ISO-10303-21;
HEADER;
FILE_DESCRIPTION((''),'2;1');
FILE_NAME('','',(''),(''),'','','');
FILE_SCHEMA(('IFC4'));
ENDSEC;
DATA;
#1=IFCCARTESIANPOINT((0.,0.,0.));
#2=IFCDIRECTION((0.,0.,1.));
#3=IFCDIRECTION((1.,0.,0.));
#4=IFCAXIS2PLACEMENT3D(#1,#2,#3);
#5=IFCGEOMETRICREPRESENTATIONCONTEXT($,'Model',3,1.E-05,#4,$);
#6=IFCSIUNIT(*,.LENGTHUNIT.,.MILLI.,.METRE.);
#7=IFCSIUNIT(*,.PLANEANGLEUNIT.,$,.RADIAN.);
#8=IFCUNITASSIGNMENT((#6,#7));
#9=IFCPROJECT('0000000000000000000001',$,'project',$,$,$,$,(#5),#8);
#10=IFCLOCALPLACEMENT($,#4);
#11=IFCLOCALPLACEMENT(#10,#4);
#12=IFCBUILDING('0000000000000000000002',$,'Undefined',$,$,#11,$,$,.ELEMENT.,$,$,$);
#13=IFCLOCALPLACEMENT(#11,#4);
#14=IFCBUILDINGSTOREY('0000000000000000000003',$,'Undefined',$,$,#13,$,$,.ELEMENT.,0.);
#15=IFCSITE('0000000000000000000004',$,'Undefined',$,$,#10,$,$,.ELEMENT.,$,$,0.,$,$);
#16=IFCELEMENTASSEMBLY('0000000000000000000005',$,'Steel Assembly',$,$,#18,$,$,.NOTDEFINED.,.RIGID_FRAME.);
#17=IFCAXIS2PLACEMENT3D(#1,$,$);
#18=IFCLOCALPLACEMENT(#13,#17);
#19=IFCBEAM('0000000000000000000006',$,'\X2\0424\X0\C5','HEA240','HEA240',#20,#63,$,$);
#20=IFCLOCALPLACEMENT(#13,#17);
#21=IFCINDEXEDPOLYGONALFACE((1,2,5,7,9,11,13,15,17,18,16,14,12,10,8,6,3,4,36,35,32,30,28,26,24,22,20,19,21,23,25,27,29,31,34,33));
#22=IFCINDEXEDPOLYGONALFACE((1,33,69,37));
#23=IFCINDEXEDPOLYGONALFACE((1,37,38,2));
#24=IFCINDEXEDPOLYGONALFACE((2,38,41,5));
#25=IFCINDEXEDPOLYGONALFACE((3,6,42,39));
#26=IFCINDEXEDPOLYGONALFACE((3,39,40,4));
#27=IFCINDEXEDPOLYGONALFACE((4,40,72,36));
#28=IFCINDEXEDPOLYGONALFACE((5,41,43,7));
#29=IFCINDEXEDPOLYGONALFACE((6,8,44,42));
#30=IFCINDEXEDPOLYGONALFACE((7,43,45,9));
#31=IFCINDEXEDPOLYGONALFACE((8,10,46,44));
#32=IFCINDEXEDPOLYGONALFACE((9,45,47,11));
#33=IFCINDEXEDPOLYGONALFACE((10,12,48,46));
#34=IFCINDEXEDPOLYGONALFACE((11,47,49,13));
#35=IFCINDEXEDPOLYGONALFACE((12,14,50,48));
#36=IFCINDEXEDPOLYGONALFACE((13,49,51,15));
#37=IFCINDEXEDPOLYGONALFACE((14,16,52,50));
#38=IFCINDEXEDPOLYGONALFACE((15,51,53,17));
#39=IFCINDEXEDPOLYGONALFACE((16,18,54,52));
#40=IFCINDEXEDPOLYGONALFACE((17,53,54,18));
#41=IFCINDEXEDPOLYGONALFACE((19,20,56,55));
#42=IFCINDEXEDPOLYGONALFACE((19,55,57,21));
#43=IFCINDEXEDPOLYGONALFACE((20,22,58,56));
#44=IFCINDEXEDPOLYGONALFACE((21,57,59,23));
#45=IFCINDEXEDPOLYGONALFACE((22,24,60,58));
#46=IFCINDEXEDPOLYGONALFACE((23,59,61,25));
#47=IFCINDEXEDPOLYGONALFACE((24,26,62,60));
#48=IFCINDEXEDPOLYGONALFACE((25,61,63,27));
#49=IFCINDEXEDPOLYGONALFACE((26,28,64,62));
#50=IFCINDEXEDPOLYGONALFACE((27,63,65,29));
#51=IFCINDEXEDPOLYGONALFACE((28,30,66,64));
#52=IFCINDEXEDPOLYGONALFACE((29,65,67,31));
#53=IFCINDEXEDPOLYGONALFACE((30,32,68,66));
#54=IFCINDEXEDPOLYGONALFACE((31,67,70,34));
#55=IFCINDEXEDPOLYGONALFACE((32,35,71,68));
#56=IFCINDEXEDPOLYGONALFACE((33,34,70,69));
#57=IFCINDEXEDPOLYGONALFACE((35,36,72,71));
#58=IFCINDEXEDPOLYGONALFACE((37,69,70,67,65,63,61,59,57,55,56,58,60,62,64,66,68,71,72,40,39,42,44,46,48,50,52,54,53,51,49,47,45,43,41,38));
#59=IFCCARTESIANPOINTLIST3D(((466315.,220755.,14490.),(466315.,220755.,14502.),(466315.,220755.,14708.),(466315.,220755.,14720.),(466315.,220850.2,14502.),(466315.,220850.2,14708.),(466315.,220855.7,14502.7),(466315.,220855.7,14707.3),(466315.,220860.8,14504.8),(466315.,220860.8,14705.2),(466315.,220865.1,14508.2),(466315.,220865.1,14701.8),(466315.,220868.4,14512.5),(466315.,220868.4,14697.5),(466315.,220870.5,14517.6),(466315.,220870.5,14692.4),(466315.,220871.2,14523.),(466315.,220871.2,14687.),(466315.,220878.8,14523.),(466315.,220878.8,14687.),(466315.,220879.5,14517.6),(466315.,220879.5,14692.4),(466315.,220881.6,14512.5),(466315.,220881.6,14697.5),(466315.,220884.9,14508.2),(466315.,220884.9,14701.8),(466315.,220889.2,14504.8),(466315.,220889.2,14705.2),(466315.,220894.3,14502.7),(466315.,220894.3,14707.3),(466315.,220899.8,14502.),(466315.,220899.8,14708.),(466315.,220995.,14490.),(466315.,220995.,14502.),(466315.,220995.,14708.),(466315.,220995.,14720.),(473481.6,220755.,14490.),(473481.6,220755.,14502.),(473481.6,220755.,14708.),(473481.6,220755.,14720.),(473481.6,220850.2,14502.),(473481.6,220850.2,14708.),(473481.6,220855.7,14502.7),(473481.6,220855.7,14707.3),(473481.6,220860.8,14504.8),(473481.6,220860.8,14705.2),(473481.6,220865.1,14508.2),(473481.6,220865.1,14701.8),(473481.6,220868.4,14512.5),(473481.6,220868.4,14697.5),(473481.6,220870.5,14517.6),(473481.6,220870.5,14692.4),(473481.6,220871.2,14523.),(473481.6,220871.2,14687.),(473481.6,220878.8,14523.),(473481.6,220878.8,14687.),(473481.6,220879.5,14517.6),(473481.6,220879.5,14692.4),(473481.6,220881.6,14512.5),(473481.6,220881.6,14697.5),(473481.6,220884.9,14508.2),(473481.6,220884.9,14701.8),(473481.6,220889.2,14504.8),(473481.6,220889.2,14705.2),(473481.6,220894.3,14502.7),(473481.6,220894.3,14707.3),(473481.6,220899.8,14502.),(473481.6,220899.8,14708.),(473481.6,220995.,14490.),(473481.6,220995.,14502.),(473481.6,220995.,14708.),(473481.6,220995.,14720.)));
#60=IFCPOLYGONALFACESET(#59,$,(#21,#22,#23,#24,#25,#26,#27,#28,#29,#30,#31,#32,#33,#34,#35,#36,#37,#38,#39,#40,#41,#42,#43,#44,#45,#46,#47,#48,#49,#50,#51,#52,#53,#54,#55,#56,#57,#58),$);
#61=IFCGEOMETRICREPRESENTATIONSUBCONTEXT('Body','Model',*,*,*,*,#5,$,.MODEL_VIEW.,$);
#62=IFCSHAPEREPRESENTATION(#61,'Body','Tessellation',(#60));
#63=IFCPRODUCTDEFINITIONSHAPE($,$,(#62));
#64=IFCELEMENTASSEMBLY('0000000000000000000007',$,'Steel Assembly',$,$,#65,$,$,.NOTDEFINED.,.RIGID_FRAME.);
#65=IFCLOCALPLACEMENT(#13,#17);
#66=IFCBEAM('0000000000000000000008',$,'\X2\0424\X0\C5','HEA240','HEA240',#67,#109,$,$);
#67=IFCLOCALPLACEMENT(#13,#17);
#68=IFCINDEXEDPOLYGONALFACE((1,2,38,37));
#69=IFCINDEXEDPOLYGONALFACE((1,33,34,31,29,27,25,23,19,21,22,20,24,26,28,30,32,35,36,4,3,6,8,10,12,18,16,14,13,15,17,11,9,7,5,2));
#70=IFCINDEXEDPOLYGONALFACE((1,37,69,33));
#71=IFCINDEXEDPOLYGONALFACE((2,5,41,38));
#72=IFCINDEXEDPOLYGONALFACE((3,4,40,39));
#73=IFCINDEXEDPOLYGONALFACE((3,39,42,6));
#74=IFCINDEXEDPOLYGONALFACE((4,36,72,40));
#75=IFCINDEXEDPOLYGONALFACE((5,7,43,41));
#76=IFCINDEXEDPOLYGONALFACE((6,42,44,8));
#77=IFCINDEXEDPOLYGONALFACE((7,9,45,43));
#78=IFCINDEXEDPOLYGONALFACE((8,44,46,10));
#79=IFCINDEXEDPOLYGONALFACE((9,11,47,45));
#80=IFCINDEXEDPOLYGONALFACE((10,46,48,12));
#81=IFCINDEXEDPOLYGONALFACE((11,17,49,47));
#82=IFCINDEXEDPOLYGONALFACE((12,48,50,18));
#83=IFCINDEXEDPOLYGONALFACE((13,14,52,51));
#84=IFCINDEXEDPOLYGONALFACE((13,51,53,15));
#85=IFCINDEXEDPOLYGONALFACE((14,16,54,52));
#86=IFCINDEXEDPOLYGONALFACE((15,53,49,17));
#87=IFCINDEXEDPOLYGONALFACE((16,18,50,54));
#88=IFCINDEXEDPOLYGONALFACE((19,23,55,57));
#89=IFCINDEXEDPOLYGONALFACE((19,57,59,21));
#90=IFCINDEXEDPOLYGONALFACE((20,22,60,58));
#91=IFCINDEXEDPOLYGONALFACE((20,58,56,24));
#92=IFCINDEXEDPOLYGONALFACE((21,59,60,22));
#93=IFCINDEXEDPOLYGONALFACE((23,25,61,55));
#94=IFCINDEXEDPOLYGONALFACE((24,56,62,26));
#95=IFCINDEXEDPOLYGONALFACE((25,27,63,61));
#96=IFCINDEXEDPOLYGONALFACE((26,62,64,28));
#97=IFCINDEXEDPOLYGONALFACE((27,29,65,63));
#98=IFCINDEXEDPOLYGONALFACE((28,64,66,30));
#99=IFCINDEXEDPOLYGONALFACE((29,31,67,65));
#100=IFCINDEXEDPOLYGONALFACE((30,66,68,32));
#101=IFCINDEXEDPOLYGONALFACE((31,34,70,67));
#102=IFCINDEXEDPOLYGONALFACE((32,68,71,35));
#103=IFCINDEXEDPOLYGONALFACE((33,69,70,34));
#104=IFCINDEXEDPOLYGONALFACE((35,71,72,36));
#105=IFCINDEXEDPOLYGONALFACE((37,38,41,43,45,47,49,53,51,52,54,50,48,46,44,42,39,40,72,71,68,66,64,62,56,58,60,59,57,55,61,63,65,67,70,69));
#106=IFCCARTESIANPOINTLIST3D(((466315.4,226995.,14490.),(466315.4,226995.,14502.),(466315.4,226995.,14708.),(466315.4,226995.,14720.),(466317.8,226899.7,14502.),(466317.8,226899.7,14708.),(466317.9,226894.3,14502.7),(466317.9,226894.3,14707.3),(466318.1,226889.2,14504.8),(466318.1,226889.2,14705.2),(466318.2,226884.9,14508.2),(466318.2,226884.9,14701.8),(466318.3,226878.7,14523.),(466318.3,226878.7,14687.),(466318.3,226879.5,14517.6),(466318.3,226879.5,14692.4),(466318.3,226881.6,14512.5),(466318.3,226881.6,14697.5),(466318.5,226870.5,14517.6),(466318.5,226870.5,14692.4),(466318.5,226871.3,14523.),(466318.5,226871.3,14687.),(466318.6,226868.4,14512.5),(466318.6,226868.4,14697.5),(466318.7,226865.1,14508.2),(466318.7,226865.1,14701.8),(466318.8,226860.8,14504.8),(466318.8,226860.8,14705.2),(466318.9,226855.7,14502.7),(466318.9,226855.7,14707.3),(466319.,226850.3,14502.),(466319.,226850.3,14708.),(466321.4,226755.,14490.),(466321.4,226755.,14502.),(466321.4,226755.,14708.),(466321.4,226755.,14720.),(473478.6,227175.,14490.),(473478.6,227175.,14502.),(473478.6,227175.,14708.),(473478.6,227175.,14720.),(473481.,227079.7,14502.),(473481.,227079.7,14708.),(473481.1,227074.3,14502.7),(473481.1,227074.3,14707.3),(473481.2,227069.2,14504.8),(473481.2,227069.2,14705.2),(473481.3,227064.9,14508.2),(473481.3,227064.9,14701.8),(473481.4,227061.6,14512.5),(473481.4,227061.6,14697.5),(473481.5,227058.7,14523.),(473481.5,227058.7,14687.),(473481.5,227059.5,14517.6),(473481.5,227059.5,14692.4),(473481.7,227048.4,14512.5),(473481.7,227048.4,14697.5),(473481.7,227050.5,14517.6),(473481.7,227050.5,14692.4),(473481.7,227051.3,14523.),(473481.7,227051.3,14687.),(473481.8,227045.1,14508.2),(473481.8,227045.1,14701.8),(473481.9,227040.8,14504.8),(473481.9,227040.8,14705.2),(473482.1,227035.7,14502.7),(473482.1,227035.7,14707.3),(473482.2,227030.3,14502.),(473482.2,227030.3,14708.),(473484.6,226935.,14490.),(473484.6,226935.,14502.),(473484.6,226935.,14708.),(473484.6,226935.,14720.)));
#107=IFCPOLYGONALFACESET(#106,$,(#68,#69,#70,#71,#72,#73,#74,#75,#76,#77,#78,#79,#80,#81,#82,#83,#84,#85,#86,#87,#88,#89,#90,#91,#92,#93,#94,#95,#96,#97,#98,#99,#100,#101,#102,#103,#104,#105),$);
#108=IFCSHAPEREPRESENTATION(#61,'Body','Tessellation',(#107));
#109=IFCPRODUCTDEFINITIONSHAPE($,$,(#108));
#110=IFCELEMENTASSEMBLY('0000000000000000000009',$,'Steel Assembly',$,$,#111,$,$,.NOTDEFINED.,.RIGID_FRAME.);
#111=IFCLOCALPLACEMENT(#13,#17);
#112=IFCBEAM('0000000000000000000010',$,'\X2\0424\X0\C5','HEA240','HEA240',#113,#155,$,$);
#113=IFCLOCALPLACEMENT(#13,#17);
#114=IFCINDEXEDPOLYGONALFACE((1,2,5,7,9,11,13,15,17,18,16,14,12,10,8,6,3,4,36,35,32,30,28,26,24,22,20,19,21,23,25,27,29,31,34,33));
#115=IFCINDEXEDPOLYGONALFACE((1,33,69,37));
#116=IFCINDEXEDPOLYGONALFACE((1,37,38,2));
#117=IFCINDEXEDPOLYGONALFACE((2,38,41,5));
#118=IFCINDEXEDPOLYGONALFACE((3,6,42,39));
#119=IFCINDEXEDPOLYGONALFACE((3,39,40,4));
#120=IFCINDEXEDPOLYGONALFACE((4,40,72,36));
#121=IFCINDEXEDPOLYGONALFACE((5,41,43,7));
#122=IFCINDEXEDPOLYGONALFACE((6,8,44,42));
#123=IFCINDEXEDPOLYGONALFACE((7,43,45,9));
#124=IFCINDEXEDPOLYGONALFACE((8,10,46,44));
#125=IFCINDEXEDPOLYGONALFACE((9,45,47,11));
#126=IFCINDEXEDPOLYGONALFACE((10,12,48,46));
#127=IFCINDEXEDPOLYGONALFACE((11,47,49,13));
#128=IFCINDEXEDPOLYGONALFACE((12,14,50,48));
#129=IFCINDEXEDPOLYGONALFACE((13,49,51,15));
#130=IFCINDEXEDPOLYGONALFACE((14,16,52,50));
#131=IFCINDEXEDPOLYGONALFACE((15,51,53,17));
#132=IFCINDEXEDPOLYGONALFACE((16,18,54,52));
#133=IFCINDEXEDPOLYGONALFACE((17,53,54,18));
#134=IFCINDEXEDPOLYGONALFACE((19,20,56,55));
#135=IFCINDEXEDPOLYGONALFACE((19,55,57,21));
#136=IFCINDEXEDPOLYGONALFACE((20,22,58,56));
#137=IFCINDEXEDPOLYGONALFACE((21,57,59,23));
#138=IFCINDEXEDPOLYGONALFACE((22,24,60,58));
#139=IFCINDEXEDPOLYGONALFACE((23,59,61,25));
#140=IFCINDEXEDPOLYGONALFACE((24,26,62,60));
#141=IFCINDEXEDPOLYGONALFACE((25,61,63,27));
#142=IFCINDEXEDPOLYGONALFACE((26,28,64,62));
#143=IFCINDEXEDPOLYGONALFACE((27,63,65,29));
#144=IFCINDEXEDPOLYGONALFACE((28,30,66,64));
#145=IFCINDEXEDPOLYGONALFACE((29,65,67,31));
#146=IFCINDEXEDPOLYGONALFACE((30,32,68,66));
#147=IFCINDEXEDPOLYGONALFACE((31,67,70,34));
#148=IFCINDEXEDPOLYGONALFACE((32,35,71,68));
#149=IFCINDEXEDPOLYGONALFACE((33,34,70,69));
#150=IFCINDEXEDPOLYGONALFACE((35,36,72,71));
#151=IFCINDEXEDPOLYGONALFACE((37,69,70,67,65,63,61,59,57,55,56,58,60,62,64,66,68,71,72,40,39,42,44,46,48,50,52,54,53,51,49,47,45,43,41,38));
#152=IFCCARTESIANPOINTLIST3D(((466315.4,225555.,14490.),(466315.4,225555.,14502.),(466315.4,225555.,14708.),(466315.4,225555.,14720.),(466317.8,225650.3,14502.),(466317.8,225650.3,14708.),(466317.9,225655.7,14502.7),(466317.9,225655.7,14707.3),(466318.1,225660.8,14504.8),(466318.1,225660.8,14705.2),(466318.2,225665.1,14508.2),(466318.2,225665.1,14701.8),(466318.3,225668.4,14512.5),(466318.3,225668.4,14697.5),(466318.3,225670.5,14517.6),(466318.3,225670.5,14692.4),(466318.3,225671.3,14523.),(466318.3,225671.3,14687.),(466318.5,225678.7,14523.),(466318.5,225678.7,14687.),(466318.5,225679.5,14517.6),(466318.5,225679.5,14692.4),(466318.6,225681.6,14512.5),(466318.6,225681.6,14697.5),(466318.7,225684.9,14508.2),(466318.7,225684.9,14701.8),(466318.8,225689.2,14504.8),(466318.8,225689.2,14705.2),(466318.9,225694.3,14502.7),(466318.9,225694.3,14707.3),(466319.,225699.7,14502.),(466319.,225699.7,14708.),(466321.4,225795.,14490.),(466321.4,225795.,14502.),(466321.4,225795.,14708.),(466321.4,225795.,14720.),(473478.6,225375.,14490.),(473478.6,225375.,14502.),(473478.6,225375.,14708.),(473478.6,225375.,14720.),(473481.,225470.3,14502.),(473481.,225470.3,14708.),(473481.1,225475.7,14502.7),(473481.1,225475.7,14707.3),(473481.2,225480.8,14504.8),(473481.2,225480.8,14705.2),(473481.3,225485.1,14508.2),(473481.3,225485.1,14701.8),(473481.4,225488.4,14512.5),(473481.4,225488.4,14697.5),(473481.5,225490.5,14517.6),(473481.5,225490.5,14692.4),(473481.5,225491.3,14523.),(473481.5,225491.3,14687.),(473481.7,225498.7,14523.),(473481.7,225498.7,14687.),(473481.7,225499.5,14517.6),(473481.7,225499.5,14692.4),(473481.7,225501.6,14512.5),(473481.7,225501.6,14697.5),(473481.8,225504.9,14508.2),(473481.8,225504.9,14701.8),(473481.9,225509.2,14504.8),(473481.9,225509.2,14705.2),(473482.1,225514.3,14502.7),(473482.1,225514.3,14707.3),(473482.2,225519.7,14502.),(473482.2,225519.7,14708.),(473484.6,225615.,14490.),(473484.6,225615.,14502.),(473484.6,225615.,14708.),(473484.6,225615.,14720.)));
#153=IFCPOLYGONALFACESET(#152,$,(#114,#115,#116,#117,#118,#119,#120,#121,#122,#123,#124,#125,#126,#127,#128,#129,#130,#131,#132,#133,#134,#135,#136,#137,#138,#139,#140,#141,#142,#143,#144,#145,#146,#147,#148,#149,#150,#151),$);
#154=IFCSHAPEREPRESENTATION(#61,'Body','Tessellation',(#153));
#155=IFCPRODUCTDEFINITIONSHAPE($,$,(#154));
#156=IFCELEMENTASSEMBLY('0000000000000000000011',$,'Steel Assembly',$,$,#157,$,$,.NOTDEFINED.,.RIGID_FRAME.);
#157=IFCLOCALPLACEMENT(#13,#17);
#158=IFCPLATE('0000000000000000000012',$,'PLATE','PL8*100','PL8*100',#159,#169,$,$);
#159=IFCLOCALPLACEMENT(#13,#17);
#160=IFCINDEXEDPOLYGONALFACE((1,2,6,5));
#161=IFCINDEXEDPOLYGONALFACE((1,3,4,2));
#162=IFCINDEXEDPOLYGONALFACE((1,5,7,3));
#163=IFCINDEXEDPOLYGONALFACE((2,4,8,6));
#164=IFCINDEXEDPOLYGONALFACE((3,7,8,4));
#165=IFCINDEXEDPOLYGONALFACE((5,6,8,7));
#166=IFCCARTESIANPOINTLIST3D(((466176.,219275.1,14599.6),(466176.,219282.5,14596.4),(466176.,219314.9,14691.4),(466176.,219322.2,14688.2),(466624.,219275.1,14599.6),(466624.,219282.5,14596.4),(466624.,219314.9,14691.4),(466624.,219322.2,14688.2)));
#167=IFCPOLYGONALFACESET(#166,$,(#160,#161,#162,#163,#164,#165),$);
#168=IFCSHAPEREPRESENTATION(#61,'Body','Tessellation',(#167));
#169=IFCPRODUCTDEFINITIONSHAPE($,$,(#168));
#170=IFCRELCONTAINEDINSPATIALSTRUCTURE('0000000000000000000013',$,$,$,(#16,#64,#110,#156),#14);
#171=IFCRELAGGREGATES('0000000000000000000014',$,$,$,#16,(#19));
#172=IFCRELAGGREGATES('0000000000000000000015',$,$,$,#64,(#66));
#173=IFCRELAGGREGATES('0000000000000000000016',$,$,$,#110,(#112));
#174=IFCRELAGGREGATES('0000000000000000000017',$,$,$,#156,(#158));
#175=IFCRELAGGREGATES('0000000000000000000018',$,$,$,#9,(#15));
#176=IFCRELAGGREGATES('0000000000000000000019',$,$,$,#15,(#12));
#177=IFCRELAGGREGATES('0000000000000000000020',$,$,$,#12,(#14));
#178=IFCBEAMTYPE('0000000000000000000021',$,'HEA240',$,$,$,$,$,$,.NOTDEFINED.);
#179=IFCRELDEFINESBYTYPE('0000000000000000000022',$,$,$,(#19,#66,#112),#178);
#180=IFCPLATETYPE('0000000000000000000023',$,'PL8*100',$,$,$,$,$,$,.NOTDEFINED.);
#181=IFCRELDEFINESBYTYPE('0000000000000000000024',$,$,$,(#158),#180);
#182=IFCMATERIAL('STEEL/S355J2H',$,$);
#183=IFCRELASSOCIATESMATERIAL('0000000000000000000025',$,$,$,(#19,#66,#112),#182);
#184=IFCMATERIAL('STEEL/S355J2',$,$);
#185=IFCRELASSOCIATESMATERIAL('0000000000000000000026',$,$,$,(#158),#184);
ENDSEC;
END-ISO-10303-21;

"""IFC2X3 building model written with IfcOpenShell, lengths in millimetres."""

from ifc_helpers import new_model, si_unit, frame, origin_with_axes, origin_2d_with_axis, place, context, subcontext, project, spatial, polyline, i_section, outline, extrude, material, type_object, element, aggregate, save


model = new_model("IFC2X3")

# Units and contexts
model_context = context("Model", 3, precision=1e-05, world=origin_with_axes())
body_context = subcontext(model_context, "Body", "Model", "MODEL_VIEW")
ifc_project = project(units=[si_unit("LENGTHUNIT", "METRE", prefix="MILLI"), si_unit("PLANEANGLEUNIT", "RADIAN")], contexts=[model_context])

# Site, building, storey
site_placement = place(None, origin_with_axes())
site = spatial("IfcSite", under=ifc_project, at=site_placement, Name="Undefined", CompositionType="ELEMENT", RefElevation=0.0)
building_placement = place(site_placement, origin_with_axes())
building = spatial("IfcBuilding", under=site, at=building_placement, Name="Undefined", CompositionType="ELEMENT")
storey_placement = place(building_placement, origin_with_axes())
storey = spatial("IfcBuildingStorey", under=building, at=storey_placement, Name="Undefined", CompositionType="ELEMENT", Elevation=0.0)

# Element assemblies, beams
ifc_material_1 = material(Name="STEEL/S355J2H")
beam_type_1 = type_object("IfcBeamType", Name="HEA240", PredefinedType="NOTDEFINED")
assembly_1_placement = place(storey_placement, origin_with_axes())
assembly_1 = element("IfcElementAssembly", 1, at=assembly_1_placement, inside=storey, Name="Steel Assembly", AssemblyPlace="NOTDEFINED", PredefinedType="RIGID_FRAME")
beam_1_placement = place(assembly_1_placement, frame((466315.0, 220875.0, 14605.0), z_axis=(0.0, 0.0, 1.0), x_axis=(1.0, 0.0, 0.0)))
beam_1 = element("IfcBeam", 2, at=beam_1_placement, type_object=beam_type_1, material=ifc_material_1, Name="ФC5", Description="HEA240", ObjectType="HEA240", context=body_context, shape_type="SweptSolid", body=[
    extrude(i_section(OverallWidth=240.0, OverallDepth=230.0, WebThickness=7.5, FlangeThickness=12.0, FilletRadius=21.0, at=origin_2d_with_axis()), frame((7166.6, 0.0, 0.0), z_axis=(-1.0, 0.0, 0.0), x_axis=(0.0, -1.0, 0.0)), (0.0, 0.0, 1.0), 7166.6),
])
aggregate(assembly_1, [beam_1])
assembly_2_placement = place(storey_placement, origin_with_axes())
assembly_2 = element("IfcElementAssembly", 3, at=assembly_2_placement, inside=storey, Name="Steel Assembly", AssemblyPlace="NOTDEFINED", PredefinedType="RIGID_FRAME")
beam_2_placement = place(assembly_2_placement, frame((466318.4, 226875.0, 14605.0), z_axis=(0.0, 0.0, 1.0), x_axis=(0.999684, 0.025121, 0.0)))
beam_2 = element("IfcBeam", 4, at=beam_2_placement, type_object=beam_type_1, material=ifc_material_1, Name="ФC5", Description="HEA240", ObjectType="HEA240", context=body_context, shape_type="SweptSolid", body=[
    extrude(i_section(OverallWidth=240.0, OverallDepth=230.0, WebThickness=7.5, FlangeThickness=12.0, FilletRadius=21.0, at=origin_2d_with_axis()), frame((7165.4, 0.0, 0.0), z_axis=(-1.0, 0.0, 0.0), x_axis=(0.0, -1.0, 0.0)), (0.0, 0.0, 1.0), 7165.4),
])
aggregate(assembly_2, [beam_2])
assembly_3_placement = place(storey_placement, origin_with_axes())
assembly_3 = element("IfcElementAssembly", 5, at=assembly_3_placement, inside=storey, Name="Steel Assembly", AssemblyPlace="NOTDEFINED", PredefinedType="RIGID_FRAME")
beam_3_placement = place(assembly_3_placement, frame((466318.4, 225675.0, 14605.0), z_axis=(0.0, 0.0, 1.0), x_axis=(0.999684, -0.025121, 0.0)))
beam_3 = element("IfcBeam", 6, at=beam_3_placement, type_object=beam_type_1, material=ifc_material_1, Name="ФC5", Description="HEA240", ObjectType="HEA240", context=body_context, shape_type="SweptSolid", body=[
    extrude(i_section(OverallWidth=240.0, OverallDepth=230.0, WebThickness=7.5, FlangeThickness=12.0, FilletRadius=21.0, at=origin_2d_with_axis()), frame((7165.4, 0.0, 0.0), z_axis=(-1.0, 0.0, 0.0), x_axis=(0.0, -1.0, 0.0)), (0.0, 0.0, 1.0), 7165.4),
])
aggregate(assembly_3, [beam_3])

# Element assembly, plate
assembly_4_placement = place(storey_placement, origin_with_axes())
assembly_4 = element("IfcElementAssembly", 7, at=assembly_4_placement, inside=storey, Name="Steel Assembly", AssemblyPlace="NOTDEFINED", PredefinedType="RIGID_FRAME")
ifc_material_2 = material(Name="STEEL/S355J2")
plate_type = type_object("IfcPlateType", Name="PL8*100", PredefinedType="NOTDEFINED")
plate_placement = place(assembly_4_placement, frame((466176.0, 219278.8, 14598.0), z_axis=(0.0, 0.917713, -0.397244), x_axis=(0.0, 0.397244, 0.917713)))
plate = element("IfcPlate", 8, at=plate_placement, type_object=plate_type, material=ifc_material_2, Name="PLATE", Description="PL8*100", ObjectType="PL8*100", context=body_context, shape_type="SweptSolid", body=[
    extrude(outline(polyline([(0.0, 0.0), (100.0, 0.0), (100.0, 448.0), (0.0, 448.0), (0.0, 0.0)])), frame((0.0, 0.0, -4.0), z_axis=(0.0, 0.0, 1.0), x_axis=(1.0, 0.0, 0.0)), (0.0, 0.0, 1.0), 8.0),
])
aggregate(assembly_4, [plate])

save(model, "model.ifc")
